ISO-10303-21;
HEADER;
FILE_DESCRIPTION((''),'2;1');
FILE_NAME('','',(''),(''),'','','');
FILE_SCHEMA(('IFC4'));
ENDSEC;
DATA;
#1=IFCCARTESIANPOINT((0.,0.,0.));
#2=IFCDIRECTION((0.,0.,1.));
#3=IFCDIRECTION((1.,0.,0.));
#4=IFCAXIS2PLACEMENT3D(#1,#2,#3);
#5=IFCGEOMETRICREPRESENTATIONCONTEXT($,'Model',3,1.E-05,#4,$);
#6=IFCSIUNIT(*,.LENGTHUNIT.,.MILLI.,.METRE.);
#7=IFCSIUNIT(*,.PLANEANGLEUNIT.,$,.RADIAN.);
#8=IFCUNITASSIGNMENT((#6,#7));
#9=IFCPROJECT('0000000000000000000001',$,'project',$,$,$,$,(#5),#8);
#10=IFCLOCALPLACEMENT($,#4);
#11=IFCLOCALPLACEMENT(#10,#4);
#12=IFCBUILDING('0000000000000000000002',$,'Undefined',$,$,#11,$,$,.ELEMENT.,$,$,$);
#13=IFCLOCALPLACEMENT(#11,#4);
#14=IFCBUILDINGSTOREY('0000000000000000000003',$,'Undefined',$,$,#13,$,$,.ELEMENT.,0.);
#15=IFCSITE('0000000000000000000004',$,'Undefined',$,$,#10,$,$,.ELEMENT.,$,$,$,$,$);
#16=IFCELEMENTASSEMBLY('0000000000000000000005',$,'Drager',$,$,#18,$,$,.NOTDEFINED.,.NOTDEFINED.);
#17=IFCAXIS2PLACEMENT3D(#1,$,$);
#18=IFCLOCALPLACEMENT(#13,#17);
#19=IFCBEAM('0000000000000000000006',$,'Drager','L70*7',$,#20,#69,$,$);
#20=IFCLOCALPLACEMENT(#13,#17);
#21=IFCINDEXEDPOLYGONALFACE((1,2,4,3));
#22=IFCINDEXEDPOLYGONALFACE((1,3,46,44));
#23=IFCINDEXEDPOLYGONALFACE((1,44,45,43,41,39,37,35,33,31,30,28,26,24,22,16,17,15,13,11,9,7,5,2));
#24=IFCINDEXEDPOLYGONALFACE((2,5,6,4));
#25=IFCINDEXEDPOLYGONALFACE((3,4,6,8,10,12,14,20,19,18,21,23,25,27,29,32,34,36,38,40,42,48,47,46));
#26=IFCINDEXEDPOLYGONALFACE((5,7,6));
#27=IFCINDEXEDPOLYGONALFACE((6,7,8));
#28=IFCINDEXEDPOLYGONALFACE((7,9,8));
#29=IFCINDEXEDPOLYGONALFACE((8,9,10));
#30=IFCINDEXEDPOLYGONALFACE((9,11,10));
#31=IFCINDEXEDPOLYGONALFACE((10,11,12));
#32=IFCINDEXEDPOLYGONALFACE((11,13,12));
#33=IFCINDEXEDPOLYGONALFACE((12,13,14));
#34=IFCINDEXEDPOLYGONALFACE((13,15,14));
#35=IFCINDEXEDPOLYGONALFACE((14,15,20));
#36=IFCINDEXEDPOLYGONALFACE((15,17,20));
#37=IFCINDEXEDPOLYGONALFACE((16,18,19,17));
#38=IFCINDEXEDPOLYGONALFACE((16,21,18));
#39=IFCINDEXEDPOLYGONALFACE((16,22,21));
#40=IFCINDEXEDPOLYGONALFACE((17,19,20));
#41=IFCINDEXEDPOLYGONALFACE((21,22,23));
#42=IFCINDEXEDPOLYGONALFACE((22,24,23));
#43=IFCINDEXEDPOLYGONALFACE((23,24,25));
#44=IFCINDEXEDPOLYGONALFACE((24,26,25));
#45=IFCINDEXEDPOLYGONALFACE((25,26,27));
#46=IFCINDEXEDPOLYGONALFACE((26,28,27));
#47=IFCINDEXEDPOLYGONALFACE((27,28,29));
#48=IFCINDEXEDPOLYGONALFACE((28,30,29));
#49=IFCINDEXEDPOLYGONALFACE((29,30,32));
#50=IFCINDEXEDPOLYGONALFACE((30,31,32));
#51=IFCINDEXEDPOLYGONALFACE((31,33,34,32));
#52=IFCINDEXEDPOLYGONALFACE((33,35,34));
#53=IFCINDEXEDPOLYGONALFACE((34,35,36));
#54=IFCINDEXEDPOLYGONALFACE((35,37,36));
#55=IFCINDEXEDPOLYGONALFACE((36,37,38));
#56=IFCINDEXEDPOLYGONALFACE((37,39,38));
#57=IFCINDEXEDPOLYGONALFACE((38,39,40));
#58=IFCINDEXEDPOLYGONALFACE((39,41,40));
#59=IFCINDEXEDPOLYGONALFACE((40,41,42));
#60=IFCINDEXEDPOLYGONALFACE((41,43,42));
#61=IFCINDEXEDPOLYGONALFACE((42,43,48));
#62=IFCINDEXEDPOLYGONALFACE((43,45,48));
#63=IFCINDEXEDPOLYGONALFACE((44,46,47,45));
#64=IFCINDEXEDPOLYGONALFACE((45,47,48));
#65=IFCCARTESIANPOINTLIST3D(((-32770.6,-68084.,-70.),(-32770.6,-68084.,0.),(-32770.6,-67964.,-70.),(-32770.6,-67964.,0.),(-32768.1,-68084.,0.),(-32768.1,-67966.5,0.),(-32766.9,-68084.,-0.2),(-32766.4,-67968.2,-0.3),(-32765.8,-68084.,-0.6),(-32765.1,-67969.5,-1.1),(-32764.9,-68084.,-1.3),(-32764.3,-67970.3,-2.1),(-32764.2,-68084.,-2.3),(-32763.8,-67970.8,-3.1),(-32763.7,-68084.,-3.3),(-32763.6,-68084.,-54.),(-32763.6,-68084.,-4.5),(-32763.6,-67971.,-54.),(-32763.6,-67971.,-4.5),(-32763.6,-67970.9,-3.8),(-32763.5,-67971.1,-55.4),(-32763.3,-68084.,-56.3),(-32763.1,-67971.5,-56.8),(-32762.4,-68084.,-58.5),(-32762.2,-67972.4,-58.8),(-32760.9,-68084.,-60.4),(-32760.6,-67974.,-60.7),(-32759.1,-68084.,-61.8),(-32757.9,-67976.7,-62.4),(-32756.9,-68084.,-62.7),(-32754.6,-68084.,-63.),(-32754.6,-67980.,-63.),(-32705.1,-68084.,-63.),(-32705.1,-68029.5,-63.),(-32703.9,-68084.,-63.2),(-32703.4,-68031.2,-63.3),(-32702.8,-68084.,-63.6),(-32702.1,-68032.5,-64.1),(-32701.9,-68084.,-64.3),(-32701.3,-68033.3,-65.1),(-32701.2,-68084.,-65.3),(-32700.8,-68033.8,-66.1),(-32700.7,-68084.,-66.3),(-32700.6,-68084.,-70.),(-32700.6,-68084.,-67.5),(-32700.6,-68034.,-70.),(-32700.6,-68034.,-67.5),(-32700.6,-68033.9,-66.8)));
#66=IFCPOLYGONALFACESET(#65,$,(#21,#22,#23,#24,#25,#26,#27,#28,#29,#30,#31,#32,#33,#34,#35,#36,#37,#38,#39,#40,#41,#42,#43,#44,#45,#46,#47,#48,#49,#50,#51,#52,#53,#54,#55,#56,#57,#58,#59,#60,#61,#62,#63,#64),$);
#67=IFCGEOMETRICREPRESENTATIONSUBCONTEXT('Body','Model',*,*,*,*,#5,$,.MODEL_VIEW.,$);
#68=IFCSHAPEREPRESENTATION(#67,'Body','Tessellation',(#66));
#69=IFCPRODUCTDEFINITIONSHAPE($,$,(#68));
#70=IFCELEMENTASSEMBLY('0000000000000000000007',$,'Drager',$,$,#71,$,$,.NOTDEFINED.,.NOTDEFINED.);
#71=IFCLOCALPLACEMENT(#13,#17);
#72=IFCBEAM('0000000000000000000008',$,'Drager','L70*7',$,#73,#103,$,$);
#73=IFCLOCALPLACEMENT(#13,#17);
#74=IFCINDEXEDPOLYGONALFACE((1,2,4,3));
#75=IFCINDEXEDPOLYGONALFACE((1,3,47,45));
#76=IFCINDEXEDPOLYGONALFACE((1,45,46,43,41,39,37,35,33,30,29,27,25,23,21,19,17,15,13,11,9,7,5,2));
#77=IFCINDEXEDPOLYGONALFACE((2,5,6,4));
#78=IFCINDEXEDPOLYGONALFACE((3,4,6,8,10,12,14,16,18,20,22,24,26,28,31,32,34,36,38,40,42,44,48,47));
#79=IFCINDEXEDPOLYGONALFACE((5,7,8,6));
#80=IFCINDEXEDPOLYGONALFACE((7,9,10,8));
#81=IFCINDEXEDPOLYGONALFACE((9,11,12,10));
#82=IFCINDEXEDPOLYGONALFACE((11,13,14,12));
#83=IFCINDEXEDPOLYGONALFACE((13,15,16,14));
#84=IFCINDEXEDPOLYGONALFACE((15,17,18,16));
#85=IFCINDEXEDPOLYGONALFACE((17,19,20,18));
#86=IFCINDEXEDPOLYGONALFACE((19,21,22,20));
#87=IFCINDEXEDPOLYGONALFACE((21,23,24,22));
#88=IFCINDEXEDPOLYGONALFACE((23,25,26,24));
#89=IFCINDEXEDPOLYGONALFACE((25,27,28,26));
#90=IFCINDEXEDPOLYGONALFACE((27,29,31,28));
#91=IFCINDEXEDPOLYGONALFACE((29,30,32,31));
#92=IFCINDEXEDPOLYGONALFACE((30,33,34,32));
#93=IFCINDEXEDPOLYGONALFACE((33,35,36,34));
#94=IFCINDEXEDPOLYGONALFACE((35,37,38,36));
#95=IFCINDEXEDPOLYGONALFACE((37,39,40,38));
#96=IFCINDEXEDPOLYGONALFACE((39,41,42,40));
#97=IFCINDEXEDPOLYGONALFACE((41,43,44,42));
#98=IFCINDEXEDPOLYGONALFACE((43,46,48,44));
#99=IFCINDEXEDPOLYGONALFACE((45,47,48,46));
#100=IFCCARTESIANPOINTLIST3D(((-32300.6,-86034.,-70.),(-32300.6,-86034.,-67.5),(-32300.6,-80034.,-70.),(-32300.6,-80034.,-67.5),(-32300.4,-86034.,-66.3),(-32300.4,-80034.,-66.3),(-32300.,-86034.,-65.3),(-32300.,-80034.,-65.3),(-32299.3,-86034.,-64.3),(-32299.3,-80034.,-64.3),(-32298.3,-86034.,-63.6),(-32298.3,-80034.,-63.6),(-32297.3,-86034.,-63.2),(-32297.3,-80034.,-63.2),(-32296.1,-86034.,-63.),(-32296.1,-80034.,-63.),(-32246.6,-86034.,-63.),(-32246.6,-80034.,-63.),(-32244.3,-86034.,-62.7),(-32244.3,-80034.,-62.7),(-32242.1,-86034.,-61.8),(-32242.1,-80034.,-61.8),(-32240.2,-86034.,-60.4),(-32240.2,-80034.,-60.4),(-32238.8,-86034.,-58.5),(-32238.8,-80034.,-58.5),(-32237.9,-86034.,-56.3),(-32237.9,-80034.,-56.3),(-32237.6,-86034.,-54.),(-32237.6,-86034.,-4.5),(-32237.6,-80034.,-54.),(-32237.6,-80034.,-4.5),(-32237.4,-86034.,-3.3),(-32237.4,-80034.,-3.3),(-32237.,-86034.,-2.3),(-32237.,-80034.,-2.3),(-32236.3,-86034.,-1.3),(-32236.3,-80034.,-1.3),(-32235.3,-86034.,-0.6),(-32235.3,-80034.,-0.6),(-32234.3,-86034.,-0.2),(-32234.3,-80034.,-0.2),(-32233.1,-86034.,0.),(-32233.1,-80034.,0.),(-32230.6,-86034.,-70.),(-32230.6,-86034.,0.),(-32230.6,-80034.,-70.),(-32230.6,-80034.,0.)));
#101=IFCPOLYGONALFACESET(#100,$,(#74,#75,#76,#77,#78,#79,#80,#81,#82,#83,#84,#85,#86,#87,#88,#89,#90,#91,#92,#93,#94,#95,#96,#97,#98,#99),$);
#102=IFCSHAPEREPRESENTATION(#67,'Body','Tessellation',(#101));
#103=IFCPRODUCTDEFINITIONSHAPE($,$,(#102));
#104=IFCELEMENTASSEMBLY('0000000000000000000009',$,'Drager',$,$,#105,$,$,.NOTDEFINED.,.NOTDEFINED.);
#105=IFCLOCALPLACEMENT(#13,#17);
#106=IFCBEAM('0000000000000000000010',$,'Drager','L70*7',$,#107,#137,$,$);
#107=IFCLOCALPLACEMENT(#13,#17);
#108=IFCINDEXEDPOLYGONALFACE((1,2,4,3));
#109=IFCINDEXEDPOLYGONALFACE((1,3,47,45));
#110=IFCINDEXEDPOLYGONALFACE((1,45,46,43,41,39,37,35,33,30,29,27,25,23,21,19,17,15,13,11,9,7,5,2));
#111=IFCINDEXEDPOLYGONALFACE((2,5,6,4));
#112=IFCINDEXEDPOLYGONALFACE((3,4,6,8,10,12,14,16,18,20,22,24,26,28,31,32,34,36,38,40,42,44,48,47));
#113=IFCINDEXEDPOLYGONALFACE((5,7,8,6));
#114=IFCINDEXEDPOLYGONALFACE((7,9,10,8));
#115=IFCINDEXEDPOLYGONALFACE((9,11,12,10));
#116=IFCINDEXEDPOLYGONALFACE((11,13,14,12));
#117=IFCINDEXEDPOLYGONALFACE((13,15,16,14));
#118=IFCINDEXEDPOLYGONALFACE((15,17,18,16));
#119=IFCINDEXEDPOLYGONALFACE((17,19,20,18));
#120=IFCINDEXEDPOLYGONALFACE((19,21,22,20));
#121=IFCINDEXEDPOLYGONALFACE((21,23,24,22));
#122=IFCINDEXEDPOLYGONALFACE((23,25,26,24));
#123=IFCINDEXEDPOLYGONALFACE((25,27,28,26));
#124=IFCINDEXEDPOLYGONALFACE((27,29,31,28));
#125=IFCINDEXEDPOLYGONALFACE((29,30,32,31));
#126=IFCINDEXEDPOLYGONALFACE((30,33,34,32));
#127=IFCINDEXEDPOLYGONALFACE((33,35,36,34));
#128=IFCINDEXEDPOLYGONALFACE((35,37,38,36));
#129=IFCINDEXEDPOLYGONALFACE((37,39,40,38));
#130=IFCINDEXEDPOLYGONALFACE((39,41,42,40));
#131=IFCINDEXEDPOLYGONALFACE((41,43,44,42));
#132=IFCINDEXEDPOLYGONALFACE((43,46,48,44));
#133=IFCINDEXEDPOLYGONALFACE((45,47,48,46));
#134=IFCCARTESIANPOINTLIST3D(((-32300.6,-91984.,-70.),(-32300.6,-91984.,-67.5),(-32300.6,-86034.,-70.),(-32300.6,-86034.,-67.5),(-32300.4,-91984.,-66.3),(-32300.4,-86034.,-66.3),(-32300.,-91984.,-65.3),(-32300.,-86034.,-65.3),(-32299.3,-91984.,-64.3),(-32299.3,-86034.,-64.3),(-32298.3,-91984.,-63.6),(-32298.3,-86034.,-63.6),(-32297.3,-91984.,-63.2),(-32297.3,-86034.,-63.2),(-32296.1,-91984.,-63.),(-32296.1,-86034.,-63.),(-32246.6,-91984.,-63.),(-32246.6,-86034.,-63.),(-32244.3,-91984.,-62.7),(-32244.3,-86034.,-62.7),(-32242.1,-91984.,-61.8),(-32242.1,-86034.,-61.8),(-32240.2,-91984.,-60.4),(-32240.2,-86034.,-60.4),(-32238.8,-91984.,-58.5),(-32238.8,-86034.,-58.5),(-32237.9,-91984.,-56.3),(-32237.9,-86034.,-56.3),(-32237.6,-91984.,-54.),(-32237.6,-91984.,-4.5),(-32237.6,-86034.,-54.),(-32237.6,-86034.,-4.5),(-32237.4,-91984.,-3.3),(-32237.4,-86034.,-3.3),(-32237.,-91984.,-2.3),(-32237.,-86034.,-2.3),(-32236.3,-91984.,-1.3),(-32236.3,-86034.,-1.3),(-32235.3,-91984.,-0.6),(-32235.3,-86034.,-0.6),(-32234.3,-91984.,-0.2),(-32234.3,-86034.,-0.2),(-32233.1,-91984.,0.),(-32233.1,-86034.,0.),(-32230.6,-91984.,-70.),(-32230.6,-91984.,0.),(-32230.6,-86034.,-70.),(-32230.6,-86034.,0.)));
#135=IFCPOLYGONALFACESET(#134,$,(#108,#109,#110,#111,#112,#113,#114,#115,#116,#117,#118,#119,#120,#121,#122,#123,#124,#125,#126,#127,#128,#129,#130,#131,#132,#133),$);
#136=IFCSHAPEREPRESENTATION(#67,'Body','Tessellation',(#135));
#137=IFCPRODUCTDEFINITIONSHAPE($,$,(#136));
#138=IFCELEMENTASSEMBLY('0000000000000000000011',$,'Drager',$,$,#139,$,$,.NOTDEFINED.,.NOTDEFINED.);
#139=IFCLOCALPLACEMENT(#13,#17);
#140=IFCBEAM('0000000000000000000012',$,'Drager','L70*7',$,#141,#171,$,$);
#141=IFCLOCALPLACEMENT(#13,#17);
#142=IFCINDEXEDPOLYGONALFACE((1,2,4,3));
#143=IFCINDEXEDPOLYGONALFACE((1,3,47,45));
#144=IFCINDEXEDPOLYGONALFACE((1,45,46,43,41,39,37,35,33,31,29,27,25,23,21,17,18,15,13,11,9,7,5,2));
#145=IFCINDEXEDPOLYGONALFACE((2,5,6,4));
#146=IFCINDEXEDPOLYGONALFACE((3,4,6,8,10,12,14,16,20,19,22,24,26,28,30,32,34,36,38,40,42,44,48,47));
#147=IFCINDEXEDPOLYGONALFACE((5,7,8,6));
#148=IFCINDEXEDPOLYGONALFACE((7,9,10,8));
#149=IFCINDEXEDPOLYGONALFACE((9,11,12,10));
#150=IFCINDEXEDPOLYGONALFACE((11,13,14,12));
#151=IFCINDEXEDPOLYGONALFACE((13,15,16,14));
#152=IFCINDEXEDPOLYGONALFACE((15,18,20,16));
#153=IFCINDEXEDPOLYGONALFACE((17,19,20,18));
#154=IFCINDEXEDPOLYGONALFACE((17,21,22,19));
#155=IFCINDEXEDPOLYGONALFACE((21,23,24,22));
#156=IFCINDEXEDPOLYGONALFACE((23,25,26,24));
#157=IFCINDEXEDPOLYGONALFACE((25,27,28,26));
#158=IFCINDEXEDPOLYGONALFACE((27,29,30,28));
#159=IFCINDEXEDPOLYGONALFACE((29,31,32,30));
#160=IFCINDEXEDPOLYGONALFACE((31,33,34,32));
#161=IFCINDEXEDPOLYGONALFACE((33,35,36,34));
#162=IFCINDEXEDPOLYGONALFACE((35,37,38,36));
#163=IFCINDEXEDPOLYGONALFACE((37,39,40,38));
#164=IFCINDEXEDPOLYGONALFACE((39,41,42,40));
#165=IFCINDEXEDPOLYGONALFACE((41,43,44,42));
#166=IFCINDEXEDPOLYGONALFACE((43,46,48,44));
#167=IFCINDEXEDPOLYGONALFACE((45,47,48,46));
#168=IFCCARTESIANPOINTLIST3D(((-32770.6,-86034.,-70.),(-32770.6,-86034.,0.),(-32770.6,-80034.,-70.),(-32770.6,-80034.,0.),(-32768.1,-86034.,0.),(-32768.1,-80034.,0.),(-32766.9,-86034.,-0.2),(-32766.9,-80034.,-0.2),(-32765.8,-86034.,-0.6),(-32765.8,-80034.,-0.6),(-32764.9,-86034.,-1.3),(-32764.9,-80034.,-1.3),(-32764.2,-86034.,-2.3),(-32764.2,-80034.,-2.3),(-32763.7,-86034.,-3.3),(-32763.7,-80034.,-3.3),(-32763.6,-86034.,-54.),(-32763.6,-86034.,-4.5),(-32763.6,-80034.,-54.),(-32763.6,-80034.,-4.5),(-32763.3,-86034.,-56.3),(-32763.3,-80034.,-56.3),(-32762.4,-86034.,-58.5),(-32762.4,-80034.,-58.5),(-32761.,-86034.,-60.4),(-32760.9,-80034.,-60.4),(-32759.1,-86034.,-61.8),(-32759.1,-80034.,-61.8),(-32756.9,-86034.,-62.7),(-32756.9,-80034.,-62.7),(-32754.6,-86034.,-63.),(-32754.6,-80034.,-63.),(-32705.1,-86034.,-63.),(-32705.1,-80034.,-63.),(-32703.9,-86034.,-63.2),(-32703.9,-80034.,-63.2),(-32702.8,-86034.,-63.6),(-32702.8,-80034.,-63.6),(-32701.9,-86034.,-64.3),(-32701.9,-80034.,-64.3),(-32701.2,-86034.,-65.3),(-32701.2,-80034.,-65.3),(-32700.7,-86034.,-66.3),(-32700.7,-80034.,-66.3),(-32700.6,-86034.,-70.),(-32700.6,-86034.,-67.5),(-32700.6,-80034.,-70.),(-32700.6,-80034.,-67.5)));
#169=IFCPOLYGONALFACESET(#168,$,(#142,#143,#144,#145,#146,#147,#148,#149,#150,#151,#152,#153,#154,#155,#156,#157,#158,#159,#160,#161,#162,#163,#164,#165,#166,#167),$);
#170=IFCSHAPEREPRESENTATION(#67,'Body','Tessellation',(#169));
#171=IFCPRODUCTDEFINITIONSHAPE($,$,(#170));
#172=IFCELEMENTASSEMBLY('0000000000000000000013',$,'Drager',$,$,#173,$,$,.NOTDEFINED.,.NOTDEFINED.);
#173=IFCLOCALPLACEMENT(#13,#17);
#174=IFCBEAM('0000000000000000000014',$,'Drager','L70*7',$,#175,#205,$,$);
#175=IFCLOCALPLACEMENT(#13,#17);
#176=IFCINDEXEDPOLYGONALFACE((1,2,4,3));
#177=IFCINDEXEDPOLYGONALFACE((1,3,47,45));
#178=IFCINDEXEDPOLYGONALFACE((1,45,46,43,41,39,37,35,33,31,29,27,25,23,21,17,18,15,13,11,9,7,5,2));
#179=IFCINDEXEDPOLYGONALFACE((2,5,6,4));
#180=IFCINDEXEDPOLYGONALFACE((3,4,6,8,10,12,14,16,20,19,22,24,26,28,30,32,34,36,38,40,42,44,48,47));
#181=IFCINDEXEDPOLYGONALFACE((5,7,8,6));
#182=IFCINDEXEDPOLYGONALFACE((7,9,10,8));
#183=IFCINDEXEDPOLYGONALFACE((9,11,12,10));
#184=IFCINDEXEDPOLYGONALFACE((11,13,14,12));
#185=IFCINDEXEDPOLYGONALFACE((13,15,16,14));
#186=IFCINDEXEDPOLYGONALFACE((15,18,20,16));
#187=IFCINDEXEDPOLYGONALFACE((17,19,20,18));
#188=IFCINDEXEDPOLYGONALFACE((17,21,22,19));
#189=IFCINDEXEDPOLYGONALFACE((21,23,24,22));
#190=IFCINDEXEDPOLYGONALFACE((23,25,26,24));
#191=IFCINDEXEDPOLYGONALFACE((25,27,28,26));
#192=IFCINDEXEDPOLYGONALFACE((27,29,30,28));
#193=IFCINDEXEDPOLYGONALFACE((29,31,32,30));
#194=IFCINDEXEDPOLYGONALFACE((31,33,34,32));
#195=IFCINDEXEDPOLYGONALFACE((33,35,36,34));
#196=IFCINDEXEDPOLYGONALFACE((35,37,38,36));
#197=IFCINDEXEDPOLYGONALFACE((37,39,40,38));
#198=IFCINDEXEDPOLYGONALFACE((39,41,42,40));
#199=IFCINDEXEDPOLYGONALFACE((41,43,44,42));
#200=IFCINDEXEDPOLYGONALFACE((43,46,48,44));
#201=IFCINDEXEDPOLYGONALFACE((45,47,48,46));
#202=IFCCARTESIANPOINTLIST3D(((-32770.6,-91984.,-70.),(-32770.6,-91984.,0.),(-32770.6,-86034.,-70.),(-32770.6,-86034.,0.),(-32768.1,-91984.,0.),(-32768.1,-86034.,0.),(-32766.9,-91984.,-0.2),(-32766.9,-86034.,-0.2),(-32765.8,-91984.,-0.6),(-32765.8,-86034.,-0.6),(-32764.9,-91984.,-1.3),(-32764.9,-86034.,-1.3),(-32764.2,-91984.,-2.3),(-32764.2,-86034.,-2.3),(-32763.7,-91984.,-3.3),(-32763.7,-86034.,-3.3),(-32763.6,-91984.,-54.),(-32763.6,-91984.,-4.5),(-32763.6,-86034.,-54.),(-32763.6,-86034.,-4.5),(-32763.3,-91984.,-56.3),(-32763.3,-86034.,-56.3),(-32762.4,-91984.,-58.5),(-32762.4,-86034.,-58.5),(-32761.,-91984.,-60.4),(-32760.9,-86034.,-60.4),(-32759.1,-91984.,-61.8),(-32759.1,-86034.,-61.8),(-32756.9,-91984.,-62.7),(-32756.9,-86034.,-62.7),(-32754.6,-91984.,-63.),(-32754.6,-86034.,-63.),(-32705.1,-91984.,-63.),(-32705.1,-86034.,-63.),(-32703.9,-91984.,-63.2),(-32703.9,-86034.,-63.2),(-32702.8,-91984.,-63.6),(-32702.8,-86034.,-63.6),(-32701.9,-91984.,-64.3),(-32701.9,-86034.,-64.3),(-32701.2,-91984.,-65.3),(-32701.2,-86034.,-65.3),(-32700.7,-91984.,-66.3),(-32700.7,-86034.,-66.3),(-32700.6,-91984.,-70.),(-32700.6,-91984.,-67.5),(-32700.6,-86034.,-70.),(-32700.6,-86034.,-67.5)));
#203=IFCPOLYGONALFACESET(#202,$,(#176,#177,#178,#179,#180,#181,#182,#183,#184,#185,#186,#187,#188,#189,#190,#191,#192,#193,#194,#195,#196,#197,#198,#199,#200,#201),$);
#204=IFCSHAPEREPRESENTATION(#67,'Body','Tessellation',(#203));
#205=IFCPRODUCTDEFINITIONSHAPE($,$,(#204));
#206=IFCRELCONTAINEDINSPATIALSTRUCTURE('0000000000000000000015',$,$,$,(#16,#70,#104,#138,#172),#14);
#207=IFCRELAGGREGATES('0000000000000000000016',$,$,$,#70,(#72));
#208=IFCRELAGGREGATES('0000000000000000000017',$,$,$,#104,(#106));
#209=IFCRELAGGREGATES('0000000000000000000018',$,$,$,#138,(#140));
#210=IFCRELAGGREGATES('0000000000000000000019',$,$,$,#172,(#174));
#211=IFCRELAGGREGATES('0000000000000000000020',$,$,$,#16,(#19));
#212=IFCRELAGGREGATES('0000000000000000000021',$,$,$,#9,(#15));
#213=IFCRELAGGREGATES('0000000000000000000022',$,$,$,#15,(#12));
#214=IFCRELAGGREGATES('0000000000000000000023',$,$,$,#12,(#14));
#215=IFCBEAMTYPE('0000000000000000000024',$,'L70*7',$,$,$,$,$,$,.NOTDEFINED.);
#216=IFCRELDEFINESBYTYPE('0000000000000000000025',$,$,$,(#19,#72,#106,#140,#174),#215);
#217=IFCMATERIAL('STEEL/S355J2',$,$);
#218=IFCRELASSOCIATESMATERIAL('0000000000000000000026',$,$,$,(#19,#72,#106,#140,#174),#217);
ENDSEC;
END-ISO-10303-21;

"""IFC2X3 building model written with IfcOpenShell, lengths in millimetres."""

from ifc_helpers import new_model, si_unit, frame, origin_with_axes, origin_2d_with_axis, place, context, subcontext, project, spatial, l_section, extrude, clip, halfspace, material, type_object, element, aggregate, save


model = new_model("IFC2X3")

# Units and contexts
model_context = context("Model", 3, precision=1e-05, world=origin_with_axes())
body_context = subcontext(model_context, "Body", "Model", "MODEL_VIEW")
ifc_project = project(units=[si_unit("LENGTHUNIT", "METRE", prefix="MILLI"), si_unit("PLANEANGLEUNIT", "RADIAN")], contexts=[model_context])

# Site, building, storey
site_placement = place(None, origin_with_axes())
site = spatial("IfcSite", under=ifc_project, at=site_placement, Name="Undefined", CompositionType="ELEMENT")
building_placement = place(site_placement, origin_with_axes())
building = spatial("IfcBuilding", under=site, at=building_placement, Name="Undefined", CompositionType="ELEMENT")
storey_placement = place(building_placement, origin_with_axes())
storey = spatial("IfcBuildingStorey", under=building, at=storey_placement, Name="Undefined", CompositionType="ELEMENT", Elevation=0.0)

# Shared definitions
ifc_material = material(Name="STEEL/S355J2")
beam_type = type_object("IfcBeamType", Name="L70*7", PredefinedType="NOTDEFINED")

# Element assembly, beam
assembly_1_placement = place(storey_placement, origin_with_axes())
assembly_1 = element("IfcElementAssembly", 1, at=assembly_1_placement, inside=storey, Name="Drager", AssemblyPlace="NOTDEFINED", PredefinedType="NOTDEFINED")
beam_1_placement = place(assembly_1_placement, frame((-32735.6, -68084.0, -35.0), z_axis=(0.0, 0.0, 1.0), x_axis=(0.0, 1.0, 0.0)))
beam_1 = element("IfcBeam", 2, at=beam_1_placement, type_object=beam_type, material=ifc_material, Name="Drager", Description="L70*7", context=body_context, shape_type="Clipping", body=[
    clip(extrude(l_section(Depth=70.0, Width=70.0, Thickness=7.0, FilletRadius=9.0, EdgeRadius=4.5, at=origin_2d_with_axis()), frame((120.3, 0.0, 0.0), z_axis=(-1.0, 0.0, 0.0), x_axis=(0.0, -1.0, 0.0)), (0.0, 0.0, 1.0), 120.3), halfspace(frame((50.0, -35.0, 35.0), z_axis=(0.707107, -0.707107, 0.0), x_axis=(0.0, 0.0, 1.0)), False)),
])

# Element assemblies, beams
assembly_2_placement = place(storey_placement, origin_with_axes())
assembly_2 = element("IfcElementAssembly", 3, at=assembly_2_placement, inside=storey, Name="Drager", AssemblyPlace="NOTDEFINED", PredefinedType="NOTDEFINED")
beam_2_placement = place(assembly_2_placement, frame((-32265.6, -80034.0, -35.0), z_axis=(0.0, 0.0, 1.0), x_axis=(0.0, -1.0, 0.0)))
beam_2 = element("IfcBeam", 4, at=beam_2_placement, type_object=beam_type, material=ifc_material, Name="Drager", Description="L70*7", context=body_context, shape_type="SweptSolid", body=[
    extrude(l_section(Depth=70.0, Width=70.0, Thickness=7.0, FilletRadius=9.0, EdgeRadius=4.5, at=origin_2d_with_axis()), frame((6000.0, 0.0, 0.0), z_axis=(-1.0, 0.0, 0.0), x_axis=(0.0, -1.0, 0.0)), (0.0, 0.0, 1.0), 6000.0),
])
aggregate(assembly_2, [beam_2])
assembly_3_placement = place(storey_placement, origin_with_axes())
assembly_3 = element("IfcElementAssembly", 5, at=assembly_3_placement, inside=storey, Name="Drager", AssemblyPlace="NOTDEFINED", PredefinedType="NOTDEFINED")
beam_3_placement = place(assembly_3_placement, frame((-32265.6, -86034.0, -35.0), z_axis=(0.0, 0.0, 1.0), x_axis=(0.0, -1.0, 0.0)))
beam_3 = element("IfcBeam", 6, at=beam_3_placement, type_object=beam_type, material=ifc_material, Name="Drager", Description="L70*7", context=body_context, shape_type="SweptSolid", body=[
    extrude(l_section(Depth=70.0, Width=70.0, Thickness=7.0, FilletRadius=9.0, EdgeRadius=4.5, at=origin_2d_with_axis()), frame((5950.0, 0.0, 0.0), z_axis=(-1.0, 0.0, 0.0), x_axis=(0.0, -1.0, 0.0)), (0.0, 0.0, 1.0), 5950.0),
])
aggregate(assembly_3, [beam_3])
assembly_4_placement = place(storey_placement, origin_with_axes())
assembly_4 = element("IfcElementAssembly", 7, at=assembly_4_placement, inside=storey, Name="Drager", AssemblyPlace="NOTDEFINED", PredefinedType="NOTDEFINED")
beam_4_placement = place(assembly_4_placement, frame((-32735.6, -86034.0, -35.0), z_axis=(0.0, 0.0, 1.0), x_axis=(0.0, 1.0, 0.0)))
beam_4 = element("IfcBeam", 8, at=beam_4_placement, type_object=beam_type, material=ifc_material, Name="Drager", Description="L70*7", context=body_context, shape_type="SweptSolid", body=[
    extrude(l_section(Depth=70.0, Width=70.0, Thickness=7.0, FilletRadius=9.0, EdgeRadius=4.5, at=origin_2d_with_axis()), frame((6000.0, 0.0, 0.0), z_axis=(-1.0, 0.0, 0.0), x_axis=(0.0, -1.0, 0.0)), (0.0, 0.0, 1.0), 6000.0),
])
aggregate(assembly_4, [beam_4])
assembly_5_placement = place(storey_placement, origin_with_axes())
assembly_5 = element("IfcElementAssembly", 9, at=assembly_5_placement, inside=storey, Name="Drager", AssemblyPlace="NOTDEFINED", PredefinedType="NOTDEFINED")
beam_5_placement = place(assembly_5_placement, frame((-32735.6, -91984.0, -35.0), z_axis=(0.0, 0.0, 1.0), x_axis=(0.0, 1.0, 0.0)))
beam_5 = element("IfcBeam", 10, at=beam_5_placement, type_object=beam_type, material=ifc_material, Name="Drager", Description="L70*7", context=body_context, shape_type="SweptSolid", body=[
    extrude(l_section(Depth=70.0, Width=70.0, Thickness=7.0, FilletRadius=9.0, EdgeRadius=4.5, at=origin_2d_with_axis()), frame((5950.0, 0.0, 0.0), z_axis=(-1.0, 0.0, 0.0), x_axis=(0.0, -1.0, 0.0)), (0.0, 0.0, 1.0), 5950.0),
])
aggregate(assembly_5, [beam_5])

aggregate(assembly_1, [beam_1])

save(model, "model.ifc")
